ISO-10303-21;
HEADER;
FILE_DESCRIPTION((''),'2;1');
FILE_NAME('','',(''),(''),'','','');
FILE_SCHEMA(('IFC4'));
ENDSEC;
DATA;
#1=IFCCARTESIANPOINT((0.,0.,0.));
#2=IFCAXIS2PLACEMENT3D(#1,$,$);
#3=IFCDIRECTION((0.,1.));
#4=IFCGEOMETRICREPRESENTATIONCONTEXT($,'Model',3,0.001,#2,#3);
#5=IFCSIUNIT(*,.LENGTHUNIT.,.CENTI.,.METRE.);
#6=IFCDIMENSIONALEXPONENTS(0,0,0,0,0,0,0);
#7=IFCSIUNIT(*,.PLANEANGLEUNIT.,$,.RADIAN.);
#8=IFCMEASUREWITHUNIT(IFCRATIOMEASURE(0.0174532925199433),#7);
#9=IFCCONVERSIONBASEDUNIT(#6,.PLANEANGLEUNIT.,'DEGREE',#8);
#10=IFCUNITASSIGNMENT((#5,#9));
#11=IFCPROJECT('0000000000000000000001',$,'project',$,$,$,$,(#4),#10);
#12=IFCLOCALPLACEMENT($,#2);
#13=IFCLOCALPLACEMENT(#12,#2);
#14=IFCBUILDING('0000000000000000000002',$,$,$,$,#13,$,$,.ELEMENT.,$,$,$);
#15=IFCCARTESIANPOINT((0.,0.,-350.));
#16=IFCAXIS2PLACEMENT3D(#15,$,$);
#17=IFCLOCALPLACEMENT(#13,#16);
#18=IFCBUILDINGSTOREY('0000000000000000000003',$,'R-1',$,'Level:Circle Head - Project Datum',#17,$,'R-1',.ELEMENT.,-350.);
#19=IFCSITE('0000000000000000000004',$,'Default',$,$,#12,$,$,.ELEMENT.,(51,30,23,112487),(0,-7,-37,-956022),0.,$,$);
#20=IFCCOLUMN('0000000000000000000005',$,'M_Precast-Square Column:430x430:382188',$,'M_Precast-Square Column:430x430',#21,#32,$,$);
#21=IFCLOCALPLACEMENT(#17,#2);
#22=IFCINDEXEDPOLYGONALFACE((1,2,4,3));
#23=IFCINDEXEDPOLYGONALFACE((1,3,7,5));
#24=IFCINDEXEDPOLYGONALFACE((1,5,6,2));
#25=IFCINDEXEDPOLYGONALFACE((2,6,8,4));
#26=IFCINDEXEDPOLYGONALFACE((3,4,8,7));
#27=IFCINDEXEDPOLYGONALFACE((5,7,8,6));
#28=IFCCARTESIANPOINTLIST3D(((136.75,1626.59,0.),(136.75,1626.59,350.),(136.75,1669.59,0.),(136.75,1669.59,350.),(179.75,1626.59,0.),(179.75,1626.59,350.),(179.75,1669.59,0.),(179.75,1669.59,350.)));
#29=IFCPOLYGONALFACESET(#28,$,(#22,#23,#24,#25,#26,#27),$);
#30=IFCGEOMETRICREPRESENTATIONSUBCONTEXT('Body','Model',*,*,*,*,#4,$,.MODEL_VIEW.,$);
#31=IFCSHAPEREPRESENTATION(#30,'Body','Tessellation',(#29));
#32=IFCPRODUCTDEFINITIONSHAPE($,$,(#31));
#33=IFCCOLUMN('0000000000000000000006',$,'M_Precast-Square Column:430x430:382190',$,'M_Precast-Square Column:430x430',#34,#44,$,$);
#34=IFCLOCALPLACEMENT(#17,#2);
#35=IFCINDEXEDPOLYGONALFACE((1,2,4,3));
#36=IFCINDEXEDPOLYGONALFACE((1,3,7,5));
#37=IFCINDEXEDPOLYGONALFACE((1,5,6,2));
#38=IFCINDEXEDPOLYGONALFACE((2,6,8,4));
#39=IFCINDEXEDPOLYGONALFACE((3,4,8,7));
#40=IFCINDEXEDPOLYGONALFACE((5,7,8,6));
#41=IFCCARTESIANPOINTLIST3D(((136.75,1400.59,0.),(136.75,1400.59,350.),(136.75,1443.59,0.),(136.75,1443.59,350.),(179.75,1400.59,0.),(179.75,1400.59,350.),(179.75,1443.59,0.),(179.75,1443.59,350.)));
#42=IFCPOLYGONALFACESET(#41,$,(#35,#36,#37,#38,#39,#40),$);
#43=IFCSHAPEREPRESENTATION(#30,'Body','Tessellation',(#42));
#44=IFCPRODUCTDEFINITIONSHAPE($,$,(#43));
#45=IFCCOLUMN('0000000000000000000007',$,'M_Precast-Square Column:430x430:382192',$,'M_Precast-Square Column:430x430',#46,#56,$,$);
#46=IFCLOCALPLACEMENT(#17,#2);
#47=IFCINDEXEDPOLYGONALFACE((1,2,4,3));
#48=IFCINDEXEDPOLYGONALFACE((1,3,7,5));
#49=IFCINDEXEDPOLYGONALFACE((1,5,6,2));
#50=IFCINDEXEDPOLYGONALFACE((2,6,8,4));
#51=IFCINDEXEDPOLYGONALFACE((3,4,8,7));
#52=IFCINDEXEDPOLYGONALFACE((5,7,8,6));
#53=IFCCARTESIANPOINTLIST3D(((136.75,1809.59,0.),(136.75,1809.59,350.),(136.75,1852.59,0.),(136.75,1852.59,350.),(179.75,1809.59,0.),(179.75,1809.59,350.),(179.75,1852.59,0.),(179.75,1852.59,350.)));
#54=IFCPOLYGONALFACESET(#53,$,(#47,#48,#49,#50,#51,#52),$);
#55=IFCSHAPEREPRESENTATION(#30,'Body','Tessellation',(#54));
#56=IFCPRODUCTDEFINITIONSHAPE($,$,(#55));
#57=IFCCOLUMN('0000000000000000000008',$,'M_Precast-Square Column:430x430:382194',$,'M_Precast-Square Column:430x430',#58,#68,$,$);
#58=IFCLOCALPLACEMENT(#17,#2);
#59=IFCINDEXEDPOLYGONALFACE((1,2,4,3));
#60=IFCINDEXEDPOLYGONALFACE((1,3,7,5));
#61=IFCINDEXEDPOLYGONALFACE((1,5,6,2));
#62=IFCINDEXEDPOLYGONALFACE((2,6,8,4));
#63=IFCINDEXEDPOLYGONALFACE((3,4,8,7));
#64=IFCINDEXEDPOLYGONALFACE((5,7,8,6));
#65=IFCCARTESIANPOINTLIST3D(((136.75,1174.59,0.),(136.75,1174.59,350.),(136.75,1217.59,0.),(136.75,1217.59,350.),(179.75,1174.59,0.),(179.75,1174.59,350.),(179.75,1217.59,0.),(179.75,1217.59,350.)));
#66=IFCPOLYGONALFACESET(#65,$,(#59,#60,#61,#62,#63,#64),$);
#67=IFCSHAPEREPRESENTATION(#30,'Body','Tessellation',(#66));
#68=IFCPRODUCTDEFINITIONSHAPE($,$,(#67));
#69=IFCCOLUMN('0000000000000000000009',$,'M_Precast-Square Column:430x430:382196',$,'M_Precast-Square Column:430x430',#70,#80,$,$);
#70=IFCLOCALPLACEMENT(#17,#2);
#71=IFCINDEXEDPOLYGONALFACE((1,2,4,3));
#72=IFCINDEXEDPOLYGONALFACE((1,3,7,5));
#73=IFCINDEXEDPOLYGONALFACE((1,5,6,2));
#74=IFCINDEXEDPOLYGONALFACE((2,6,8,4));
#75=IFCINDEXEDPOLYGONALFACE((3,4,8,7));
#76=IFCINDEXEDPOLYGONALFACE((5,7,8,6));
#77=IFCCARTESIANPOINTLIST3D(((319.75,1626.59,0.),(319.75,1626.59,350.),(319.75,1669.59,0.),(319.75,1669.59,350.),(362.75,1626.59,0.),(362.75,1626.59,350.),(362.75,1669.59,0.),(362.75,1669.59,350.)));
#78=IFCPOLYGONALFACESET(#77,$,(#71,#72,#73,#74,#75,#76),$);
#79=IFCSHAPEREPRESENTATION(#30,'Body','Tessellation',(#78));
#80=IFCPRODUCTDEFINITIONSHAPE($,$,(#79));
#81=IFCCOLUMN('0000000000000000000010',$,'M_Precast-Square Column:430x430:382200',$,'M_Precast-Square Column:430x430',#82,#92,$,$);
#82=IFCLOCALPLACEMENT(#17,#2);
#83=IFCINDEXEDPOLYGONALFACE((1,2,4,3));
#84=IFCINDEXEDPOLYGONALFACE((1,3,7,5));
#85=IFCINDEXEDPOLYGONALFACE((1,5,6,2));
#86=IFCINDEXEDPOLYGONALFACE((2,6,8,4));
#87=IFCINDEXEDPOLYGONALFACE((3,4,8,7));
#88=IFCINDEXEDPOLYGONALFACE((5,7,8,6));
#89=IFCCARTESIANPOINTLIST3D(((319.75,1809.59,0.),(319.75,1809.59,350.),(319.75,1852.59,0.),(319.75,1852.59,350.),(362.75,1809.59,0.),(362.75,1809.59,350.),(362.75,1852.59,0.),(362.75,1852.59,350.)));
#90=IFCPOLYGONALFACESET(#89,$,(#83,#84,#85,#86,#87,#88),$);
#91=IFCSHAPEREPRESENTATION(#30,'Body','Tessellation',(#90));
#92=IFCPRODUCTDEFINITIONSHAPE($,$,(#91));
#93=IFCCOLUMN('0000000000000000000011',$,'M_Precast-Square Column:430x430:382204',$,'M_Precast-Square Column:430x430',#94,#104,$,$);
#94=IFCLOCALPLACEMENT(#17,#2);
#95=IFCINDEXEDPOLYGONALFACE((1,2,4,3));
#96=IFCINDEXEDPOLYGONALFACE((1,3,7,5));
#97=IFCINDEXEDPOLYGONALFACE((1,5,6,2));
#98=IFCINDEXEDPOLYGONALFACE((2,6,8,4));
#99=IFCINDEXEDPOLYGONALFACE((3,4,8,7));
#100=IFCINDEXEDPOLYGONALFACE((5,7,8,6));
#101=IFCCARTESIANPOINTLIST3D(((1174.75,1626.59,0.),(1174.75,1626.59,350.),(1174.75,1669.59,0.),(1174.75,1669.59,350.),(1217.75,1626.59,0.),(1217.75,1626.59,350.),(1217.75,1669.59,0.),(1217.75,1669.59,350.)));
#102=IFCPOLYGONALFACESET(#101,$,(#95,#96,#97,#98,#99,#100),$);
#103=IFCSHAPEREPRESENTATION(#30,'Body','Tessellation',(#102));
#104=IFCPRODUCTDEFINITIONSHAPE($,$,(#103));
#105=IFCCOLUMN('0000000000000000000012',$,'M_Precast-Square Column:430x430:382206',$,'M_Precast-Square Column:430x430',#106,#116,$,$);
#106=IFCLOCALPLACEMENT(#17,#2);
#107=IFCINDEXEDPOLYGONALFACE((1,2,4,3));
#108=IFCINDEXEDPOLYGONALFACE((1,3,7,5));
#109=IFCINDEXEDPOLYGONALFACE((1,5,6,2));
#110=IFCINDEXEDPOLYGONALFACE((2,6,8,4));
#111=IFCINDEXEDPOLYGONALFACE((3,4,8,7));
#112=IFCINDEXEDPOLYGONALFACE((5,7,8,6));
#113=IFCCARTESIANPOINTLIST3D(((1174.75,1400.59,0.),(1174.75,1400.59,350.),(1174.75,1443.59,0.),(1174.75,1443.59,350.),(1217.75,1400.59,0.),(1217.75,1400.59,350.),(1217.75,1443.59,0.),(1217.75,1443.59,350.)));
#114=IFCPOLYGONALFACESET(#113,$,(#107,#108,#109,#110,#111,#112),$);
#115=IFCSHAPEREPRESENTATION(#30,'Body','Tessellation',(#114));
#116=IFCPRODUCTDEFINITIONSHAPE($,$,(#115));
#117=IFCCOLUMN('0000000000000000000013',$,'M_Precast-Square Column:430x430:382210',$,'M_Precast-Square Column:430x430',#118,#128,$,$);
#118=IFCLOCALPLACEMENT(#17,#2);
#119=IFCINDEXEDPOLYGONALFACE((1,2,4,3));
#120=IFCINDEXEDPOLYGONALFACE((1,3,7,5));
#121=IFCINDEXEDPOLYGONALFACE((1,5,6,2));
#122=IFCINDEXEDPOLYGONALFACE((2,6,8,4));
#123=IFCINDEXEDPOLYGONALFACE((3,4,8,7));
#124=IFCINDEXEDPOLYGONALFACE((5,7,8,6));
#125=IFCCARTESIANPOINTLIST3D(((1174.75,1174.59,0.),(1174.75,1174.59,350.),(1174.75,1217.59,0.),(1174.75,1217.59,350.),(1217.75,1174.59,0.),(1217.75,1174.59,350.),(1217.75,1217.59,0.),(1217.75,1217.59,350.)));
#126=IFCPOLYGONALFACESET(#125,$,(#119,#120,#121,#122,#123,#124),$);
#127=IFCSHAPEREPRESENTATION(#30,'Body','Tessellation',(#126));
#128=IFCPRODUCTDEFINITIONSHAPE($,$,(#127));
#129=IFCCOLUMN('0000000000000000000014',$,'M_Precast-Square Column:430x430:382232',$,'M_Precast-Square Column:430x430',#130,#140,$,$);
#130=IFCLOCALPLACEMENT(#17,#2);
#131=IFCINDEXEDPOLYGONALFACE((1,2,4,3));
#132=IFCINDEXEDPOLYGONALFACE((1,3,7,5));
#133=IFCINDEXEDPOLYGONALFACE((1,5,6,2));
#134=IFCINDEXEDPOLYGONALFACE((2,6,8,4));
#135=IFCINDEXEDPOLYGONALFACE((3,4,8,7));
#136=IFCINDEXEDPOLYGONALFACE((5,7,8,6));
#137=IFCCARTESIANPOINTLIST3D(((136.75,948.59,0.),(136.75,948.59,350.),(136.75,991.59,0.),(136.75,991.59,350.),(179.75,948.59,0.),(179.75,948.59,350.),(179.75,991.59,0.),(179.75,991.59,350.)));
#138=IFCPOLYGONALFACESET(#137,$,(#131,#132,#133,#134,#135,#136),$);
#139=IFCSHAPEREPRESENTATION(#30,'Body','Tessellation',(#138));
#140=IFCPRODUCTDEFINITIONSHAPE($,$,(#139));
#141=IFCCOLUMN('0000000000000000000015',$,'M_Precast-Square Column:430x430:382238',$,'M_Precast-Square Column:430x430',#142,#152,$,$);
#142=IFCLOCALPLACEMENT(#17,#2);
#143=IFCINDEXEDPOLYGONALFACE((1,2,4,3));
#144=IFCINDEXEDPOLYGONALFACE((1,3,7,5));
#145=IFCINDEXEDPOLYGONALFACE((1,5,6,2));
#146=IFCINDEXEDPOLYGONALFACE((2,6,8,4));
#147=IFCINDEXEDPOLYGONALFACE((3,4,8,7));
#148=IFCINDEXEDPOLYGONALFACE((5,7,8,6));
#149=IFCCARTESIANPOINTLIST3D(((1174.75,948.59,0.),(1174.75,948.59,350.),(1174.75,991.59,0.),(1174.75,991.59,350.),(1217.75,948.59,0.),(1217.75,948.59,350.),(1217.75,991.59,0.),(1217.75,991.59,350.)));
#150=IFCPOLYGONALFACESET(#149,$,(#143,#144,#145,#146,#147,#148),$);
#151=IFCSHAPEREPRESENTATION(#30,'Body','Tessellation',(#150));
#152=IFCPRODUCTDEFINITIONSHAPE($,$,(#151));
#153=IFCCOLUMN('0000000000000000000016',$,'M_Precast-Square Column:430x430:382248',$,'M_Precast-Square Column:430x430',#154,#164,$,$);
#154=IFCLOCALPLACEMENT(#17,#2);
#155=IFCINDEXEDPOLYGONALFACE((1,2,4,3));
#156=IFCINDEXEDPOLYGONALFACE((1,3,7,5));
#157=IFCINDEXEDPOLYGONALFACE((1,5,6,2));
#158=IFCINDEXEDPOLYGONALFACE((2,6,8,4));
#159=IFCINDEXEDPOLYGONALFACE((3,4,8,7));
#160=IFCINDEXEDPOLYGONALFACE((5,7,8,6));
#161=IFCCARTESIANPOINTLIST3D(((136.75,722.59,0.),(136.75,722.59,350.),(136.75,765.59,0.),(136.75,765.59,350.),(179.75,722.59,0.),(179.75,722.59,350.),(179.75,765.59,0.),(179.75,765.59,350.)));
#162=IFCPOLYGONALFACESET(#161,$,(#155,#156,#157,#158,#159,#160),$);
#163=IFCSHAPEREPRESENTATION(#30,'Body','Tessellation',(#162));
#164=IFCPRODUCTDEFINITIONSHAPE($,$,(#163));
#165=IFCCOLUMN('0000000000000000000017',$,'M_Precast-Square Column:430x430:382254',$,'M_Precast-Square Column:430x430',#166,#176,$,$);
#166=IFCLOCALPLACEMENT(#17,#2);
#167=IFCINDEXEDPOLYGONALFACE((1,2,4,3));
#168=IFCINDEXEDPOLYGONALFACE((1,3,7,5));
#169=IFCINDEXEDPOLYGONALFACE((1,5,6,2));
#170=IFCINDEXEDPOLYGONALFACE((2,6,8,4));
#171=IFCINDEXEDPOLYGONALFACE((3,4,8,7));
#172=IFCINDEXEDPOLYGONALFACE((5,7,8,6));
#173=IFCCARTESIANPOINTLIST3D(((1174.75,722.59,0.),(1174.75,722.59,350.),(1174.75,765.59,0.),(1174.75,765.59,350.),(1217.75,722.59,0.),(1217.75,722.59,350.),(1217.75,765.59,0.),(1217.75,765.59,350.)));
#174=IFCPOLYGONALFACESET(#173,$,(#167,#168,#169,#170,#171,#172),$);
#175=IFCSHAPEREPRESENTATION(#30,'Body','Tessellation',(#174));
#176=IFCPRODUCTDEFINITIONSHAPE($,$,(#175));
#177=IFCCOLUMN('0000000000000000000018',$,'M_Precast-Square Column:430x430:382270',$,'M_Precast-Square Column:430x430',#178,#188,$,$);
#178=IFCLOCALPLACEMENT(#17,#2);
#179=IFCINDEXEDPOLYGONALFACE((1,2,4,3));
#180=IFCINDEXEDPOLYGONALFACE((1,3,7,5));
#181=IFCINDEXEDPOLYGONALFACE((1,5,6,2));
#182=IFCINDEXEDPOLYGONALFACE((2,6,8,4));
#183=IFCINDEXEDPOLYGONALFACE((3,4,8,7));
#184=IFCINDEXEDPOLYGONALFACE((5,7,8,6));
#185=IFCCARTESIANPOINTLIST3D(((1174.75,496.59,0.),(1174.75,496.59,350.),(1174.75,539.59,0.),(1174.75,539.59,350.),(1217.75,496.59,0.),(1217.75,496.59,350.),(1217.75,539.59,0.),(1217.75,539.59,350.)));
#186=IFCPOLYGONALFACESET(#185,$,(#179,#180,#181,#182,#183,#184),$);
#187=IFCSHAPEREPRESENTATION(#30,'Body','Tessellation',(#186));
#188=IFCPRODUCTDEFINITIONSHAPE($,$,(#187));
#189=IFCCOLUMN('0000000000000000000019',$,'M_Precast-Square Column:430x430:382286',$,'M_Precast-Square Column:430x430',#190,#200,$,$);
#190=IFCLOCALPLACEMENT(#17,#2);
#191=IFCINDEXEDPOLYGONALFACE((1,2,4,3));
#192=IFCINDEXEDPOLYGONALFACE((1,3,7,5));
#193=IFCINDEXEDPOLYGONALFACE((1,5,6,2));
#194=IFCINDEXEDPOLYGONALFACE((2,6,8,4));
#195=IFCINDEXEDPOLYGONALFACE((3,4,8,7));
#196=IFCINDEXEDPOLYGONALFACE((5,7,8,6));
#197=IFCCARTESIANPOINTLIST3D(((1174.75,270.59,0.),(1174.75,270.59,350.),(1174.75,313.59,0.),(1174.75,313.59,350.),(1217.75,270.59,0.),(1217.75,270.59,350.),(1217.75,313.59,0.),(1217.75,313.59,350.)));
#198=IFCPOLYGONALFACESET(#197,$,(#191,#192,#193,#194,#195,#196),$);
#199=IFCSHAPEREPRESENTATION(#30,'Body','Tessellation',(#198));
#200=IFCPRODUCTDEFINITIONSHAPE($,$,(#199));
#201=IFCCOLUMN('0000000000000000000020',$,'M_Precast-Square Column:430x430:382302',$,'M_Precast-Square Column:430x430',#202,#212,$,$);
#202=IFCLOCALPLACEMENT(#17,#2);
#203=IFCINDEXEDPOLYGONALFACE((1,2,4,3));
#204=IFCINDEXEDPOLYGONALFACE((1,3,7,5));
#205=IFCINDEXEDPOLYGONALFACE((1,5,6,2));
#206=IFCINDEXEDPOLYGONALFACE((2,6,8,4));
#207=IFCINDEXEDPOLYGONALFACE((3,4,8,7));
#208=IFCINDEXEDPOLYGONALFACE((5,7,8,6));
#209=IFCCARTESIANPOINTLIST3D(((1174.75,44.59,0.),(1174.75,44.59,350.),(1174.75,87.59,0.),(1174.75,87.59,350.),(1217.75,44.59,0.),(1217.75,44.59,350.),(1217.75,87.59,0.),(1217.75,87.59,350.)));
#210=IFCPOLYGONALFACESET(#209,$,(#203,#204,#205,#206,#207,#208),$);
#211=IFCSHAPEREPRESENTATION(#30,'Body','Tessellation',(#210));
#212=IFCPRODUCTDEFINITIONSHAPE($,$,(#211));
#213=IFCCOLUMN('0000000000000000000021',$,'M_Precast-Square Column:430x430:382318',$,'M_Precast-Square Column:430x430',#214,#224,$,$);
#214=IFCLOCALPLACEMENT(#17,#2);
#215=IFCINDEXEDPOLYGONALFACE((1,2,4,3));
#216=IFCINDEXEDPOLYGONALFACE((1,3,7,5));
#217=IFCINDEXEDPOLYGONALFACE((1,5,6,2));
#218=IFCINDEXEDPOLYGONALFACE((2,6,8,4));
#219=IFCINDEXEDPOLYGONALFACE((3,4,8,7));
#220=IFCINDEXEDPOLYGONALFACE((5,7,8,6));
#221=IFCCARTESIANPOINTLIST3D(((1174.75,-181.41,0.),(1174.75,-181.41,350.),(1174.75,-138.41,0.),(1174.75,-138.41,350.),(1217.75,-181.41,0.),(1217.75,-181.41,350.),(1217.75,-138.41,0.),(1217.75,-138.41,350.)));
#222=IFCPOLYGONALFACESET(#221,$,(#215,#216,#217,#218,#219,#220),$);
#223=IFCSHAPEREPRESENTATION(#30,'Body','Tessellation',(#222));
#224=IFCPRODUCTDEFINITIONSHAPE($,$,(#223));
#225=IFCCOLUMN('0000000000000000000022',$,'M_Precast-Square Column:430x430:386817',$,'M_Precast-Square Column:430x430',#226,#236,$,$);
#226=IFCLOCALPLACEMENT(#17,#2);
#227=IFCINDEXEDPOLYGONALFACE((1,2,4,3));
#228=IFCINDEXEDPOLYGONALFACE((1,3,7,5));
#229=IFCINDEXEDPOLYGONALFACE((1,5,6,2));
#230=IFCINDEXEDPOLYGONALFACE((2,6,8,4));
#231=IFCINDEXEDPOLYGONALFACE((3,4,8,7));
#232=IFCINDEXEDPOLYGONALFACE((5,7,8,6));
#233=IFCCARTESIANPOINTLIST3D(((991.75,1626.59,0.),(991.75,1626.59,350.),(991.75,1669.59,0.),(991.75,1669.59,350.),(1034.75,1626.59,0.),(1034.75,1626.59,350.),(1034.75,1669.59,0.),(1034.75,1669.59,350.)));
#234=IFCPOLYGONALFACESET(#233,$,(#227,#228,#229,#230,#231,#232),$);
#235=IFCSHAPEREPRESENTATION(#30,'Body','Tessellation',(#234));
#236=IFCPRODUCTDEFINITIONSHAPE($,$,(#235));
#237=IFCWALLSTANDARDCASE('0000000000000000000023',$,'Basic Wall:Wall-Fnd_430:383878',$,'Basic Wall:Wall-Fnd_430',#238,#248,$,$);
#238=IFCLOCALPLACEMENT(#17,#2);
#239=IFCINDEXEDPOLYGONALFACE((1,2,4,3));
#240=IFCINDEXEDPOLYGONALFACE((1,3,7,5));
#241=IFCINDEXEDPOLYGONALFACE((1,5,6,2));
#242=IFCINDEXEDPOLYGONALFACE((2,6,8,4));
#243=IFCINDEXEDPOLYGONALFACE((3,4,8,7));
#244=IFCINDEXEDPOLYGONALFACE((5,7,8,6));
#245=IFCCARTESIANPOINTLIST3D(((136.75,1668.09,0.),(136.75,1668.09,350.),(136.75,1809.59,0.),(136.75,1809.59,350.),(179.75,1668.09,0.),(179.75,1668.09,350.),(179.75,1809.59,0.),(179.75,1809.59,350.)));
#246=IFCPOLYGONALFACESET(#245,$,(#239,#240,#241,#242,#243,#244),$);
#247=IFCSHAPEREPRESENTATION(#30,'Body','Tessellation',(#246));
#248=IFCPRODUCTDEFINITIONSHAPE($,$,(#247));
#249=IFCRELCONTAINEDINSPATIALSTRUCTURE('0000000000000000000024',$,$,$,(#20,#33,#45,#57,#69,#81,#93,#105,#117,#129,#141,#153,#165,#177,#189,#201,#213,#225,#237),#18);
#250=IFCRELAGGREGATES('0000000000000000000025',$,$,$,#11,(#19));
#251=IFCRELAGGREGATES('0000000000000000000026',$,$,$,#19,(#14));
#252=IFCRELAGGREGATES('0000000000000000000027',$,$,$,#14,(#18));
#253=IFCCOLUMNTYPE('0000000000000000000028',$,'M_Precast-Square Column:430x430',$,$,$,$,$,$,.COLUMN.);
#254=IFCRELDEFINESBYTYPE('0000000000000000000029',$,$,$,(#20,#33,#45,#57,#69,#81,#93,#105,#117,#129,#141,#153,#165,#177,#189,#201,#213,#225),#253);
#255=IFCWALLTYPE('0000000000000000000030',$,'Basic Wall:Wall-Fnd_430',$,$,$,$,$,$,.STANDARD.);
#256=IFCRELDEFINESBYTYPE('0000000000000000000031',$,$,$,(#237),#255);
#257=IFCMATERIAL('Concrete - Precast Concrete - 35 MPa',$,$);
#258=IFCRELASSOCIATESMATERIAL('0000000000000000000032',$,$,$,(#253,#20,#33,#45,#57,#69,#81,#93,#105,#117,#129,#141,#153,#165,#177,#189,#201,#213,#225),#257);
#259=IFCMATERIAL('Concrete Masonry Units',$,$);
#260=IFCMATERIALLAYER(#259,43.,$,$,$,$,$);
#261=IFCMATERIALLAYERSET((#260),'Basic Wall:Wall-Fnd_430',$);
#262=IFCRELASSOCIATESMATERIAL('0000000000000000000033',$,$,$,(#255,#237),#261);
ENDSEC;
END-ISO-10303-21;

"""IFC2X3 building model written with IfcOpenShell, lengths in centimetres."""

from ifc_helpers import new_model, entity, si_unit, converted_unit, direction, frame, frame_2d, origin, origin_2d_with_axis, place, context, subcontext, project, spatial, rectangle, extrude, source, transform, mapped, material, layer, layer_set, layer_usage, type_object, type_shapes, element, save


model = new_model("IFC2X3")

# Units and contexts
model_context = context("Model", 3, precision=0.001, world=origin(), true_north=direction((0.0, 1.0)))
body_context = subcontext(model_context, "Body", "Model", "MODEL_VIEW")
ifc_project = project(units=[si_unit("LENGTHUNIT", "METRE", prefix="CENTI"), converted_unit("PLANEANGLEUNIT", "DEGREE", entity("IfcRatioMeasure", 0.0174532925199433), si_unit("PLANEANGLEUNIT", "RADIAN"), dimensions=[0, 0, 0, 0, 0, 0, 0])], contexts=[model_context])

# Site, building, storey
site_placement = place(None, origin())
site = spatial("IfcSite", under=ifc_project, at=site_placement, Name="Default", CompositionType="ELEMENT", RefLatitude=(51, 30, 23, 112487), RefLongitude=(0, -7, -37, -956022), RefElevation=0.0)
building_placement = place(site_placement, origin())
building = spatial("IfcBuilding", under=site, at=building_placement, CompositionType="ELEMENT")
storey_placement = place(building_placement, frame((0.0, 0.0, -350.0)))
storey = spatial("IfcBuildingStorey", under=building, at=storey_placement, Name="R-1", ObjectType="Level:Circle Head - Project Datum", LongName="R-1", CompositionType="ELEMENT", Elevation=-350.0)

# Columns
ifc_material_1 = material(Name="Concrete - Precast Concrete - 35 MPa")
column_type = type_object("IfcColumnType", Name="M_Precast-Square Column:430x430", PredefinedType="COLUMN", material=ifc_material_1)
shared_shape = source(origin(), body_context, "Body", "SweptSolid", [
    extrude(rectangle(XDim=43.0, YDim=43.0, at=origin_2d_with_axis()), frame((0.0, 0.0, -350.0), z_axis=(0.0, 0.0, 1.0), x_axis=(0.0, -1.0, 0.0)), (0.0, 0.0, 1.0), 350.0),
])
type_shapes(column_type, [shared_shape])
for number, where, z_axis, x_axis, name in (
    (1, (158.25, 1648.09, 350.0), (0.0, 0.0, 1.0), (-1.0, 0.0, 0.0), "M_Precast-Square Column:430x430:382188"),
    (2, (158.25, 1422.09, 350.0), (0.0, 0.0, 1.0), (-1.0, 0.0, 0.0), "M_Precast-Square Column:430x430:382190"),
    (3, (158.25, 1831.09, 350.0), (0.0, 0.0, 1.0), (-1.0, 0.0, 0.0), "M_Precast-Square Column:430x430:382192"),
    (4, (158.25, 1196.09, 350.0), (0.0, 0.0, 1.0), (-1.0, 0.0, 0.0), "M_Precast-Square Column:430x430:382194"),
    (5, (341.25, 1648.09, 350.0), (0.0, 0.0, 1.0), (-1.0, 0.0, 0.0), "M_Precast-Square Column:430x430:382196"),
    (6, (341.25, 1831.09, 350.0), (0.0, 0.0, 1.0), (-1.0, 0.0, 0.0), "M_Precast-Square Column:430x430:382200"),
    (7, (1196.25, 1648.09, 350.0), (0.0, 0.0, 1.0), (-1.0, 0.0, 0.0), "M_Precast-Square Column:430x430:382204"),
    (8, (1196.25, 1422.09, 350.0), (0.0, 0.0, 1.0), (-1.0, 0.0, 0.0), "M_Precast-Square Column:430x430:382206"),
    (9, (1196.25, 1196.09, 350.0), (0.0, 0.0, 1.0), (-1.0, 0.0, 0.0), "M_Precast-Square Column:430x430:382210"),
    (10, (158.25, 970.09, 350.0), (0.0, 0.0, 1.0), (-1.0, 0.0, 0.0), "M_Precast-Square Column:430x430:382232"),
    (11, (1196.25, 970.09, 350.0), (0.0, 0.0, 1.0), (-1.0, 0.0, 0.0), "M_Precast-Square Column:430x430:382238"),
    (12, (158.25, 744.09, 350.0), (0.0, 0.0, 1.0), (-1.0, 0.0, 0.0), "M_Precast-Square Column:430x430:382248"),
    (13, (1196.25, 744.09, 350.0), (0.0, 0.0, 1.0), (-1.0, 0.0, 0.0), "M_Precast-Square Column:430x430:382254"),
    (14, (1196.25, 518.09, 350.0), (0.0, 0.0, 1.0), (-1.0, 0.0, 0.0), "M_Precast-Square Column:430x430:382270"),
    (15, (1196.25, 292.09, 350.0), (0.0, 0.0, 1.0), (-1.0, 0.0, 0.0), "M_Precast-Square Column:430x430:382286"),
    (16, (1196.25, 66.09, 350.0), (0.0, 0.0, 1.0), (-1.0, 0.0, 0.0), "M_Precast-Square Column:430x430:382302"),
    (17, (1196.25, -159.91, 350.0), (0.0, 0.0, 1.0), (-1.0, 0.0, 0.0), "M_Precast-Square Column:430x430:382318"),
    (18, (1013.25, 1648.09, 350.0), (0.0, 0.0, 1.0), (-1.0, 0.0, 0.0), "M_Precast-Square Column:430x430:386817"),
):
    element("IfcColumn", number, at=place(storey_placement, frame(where, z_axis=z_axis, x_axis=x_axis)), inside=storey, type_object=column_type, material=ifc_material_1, Name=name, ObjectType="M_Precast-Square Column:430x430", context=body_context, shape_type="MappedRepresentation", body=[
        mapped(shared_shape, transform((0.0, 0.0, 0.0), scale=1.0)),
    ])

# Wall
ifc_material_2 = material(Name="Concrete Masonry Units")
ifc_layer_1 = layer(ifc_material_2, 43.0)
ifc_layer_set_1 = layer_set([ifc_layer_1], Name="Basic Wall:Wall-Fnd_430")
ifc_layer_usage_1 = layer_usage(ifc_layer_set_1, "AXIS2", "NEGATIVE", 21.5)
wall_type_1 = type_object("IfcWallType", Name="Basic Wall:Wall-Fnd_430", PredefinedType="STANDARD", material=ifc_layer_set_1)
wall_1_placement = place(storey_placement, frame((158.25, 1809.59, 0.0), z_axis=(0.0, 0.0, 1.0), x_axis=(0.0, -1.0, 0.0)))
element("IfcWallStandardCase", 19, at=wall_1_placement, inside=storey, type_object=wall_type_1, material=ifc_layer_usage_1, Name="Basic Wall:Wall-Fnd_430:383878", ObjectType="Basic Wall:Wall-Fnd_430", context=body_context, shape_type="SweptSolid", body=[
    extrude(rectangle(XDim=141.5, YDim=43.0, at=frame_2d((70.75, 0.0), x_axis=(-1.0, 0.0))), origin(), (0.0, 0.0, 1.0), 350.0),
])

save(model, "model.ifc")
